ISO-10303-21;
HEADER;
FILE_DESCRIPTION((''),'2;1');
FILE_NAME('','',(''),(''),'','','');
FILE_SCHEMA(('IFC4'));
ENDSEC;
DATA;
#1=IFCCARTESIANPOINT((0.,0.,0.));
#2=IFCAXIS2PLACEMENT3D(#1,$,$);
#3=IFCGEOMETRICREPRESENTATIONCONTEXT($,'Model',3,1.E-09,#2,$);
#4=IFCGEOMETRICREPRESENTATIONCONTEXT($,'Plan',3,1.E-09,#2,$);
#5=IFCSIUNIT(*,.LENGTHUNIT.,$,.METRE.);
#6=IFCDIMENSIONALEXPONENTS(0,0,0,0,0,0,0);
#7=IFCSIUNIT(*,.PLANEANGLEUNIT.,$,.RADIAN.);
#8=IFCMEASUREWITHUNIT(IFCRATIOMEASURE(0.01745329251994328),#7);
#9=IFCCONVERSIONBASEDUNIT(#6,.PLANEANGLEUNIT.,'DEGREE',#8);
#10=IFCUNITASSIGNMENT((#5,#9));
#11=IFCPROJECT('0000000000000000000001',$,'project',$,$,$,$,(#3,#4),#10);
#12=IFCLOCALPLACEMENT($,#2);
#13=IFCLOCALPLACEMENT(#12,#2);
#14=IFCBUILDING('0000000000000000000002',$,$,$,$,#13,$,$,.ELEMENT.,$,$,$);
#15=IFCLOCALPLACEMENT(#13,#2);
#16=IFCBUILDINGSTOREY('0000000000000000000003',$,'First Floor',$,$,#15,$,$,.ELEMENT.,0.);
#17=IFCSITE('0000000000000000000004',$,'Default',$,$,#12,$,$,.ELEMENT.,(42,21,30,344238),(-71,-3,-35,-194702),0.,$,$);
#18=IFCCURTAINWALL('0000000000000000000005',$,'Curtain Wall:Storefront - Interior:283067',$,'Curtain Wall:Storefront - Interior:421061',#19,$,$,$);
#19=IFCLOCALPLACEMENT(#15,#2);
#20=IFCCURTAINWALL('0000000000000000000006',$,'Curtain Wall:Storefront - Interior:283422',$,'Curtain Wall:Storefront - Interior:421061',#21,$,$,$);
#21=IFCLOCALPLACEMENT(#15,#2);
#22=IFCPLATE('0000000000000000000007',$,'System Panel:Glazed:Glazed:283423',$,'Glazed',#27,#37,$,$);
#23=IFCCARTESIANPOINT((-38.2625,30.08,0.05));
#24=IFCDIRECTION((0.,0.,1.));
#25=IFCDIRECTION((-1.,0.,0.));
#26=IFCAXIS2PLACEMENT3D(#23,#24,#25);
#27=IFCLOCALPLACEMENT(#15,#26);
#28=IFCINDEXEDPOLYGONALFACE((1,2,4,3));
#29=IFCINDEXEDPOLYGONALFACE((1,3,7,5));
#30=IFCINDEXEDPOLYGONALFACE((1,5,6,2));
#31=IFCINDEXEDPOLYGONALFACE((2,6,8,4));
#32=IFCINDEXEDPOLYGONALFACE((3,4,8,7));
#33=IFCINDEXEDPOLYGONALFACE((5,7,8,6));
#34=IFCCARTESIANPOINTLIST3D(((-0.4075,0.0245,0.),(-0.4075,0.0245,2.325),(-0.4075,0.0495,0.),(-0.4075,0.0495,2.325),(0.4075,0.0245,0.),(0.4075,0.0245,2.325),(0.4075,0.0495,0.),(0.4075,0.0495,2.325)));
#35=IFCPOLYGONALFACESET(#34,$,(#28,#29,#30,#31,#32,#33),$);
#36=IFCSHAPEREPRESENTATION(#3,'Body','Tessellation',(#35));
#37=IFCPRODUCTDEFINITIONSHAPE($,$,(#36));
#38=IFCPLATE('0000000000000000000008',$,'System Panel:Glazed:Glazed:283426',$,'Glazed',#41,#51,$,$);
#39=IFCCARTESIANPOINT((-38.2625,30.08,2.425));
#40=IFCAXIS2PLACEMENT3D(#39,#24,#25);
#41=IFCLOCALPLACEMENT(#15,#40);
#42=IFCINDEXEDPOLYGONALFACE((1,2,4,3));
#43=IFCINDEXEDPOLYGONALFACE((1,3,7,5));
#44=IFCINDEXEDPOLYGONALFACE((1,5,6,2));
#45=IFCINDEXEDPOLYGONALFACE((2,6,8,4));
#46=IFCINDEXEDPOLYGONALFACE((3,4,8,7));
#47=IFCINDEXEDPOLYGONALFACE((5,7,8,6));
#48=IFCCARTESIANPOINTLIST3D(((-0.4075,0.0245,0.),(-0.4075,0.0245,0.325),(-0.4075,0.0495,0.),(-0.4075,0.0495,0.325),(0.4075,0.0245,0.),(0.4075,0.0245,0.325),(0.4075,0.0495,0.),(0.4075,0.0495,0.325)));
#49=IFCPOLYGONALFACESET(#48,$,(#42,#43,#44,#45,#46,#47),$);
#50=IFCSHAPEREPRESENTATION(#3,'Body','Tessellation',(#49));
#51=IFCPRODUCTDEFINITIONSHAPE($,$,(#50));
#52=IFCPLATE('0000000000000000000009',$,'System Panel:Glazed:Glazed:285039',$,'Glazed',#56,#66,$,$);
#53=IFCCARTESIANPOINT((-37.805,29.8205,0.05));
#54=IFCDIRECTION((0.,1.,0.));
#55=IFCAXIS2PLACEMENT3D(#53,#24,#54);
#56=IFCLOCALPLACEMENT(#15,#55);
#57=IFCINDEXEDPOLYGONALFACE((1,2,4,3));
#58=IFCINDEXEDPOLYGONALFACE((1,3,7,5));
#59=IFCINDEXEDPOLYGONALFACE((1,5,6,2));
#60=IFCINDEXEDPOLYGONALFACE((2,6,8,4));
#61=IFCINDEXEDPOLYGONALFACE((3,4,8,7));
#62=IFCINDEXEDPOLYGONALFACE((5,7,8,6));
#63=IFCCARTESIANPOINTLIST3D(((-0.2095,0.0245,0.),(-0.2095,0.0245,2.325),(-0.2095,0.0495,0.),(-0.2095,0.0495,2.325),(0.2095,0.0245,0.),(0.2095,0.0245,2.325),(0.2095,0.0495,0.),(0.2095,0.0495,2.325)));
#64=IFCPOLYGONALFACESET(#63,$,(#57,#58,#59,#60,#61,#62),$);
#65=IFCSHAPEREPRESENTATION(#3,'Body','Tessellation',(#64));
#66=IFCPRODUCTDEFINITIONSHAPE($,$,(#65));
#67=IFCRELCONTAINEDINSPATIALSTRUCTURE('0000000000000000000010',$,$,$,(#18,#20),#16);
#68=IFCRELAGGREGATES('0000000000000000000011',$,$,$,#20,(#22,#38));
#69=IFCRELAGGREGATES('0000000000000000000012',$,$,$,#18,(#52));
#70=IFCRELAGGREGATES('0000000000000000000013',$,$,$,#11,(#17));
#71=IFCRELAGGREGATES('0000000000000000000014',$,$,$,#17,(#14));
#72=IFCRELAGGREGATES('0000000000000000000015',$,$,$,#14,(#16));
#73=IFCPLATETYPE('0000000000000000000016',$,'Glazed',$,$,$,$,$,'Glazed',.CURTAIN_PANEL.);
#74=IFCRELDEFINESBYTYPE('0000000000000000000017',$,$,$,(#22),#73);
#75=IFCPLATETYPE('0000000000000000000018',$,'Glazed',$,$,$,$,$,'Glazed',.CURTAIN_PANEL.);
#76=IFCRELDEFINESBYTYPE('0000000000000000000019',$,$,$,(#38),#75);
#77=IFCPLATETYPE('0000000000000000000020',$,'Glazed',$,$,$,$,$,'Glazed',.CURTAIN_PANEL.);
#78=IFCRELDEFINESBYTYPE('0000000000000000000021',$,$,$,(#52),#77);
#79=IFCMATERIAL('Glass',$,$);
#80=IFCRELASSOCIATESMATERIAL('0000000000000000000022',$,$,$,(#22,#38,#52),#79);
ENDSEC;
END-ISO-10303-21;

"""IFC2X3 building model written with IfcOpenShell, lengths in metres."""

from ifc_helpers import new_model, entity, si_unit, converted_unit, frame, origin, origin_2d_with_axis, place, context, project, spatial, rectangle, extrude, source, transform, mapped, material, type_object, type_shapes, element, aggregate, save


model = new_model("IFC2X3")

# Units and contexts
model_context = context("Model", 3, precision=1e-09, world=origin())
plan_context = context("Plan", 3, precision=1e-09, world=origin())
ifc_project = project(units=[si_unit("LENGTHUNIT", "METRE"), converted_unit("PLANEANGLEUNIT", "DEGREE", entity("IfcRatioMeasure", 0.01745329251994328), si_unit("PLANEANGLEUNIT", "RADIAN"), dimensions=[0, 0, 0, 0, 0, 0, 0])], contexts=[model_context, plan_context])

# Site, building, storey
site_placement = place(None, origin())
site = spatial("IfcSite", under=ifc_project, at=site_placement, Name="Default", CompositionType="ELEMENT", RefLatitude=(42, 21, 30, 344238), RefLongitude=(-71, -3, -35, -194702), RefElevation=0.0)
building_placement = place(site_placement, origin())
building = spatial("IfcBuilding", under=site, at=building_placement, CompositionType="ELEMENT")
storey_placement = place(building_placement, origin())
storey = spatial("IfcBuildingStorey", under=building, at=storey_placement, Name="First Floor", CompositionType="ELEMENT", Elevation=0.0)

# Curtain walls
curtain_wall_1_placement = place(storey_placement, origin())
curtain_wall_1 = element("IfcCurtainWall", 1, at=curtain_wall_1_placement, inside=storey, Name="Curtain Wall:Storefront - Interior:283067", ObjectType="Curtain Wall:Storefront - Interior:421061")
curtain_wall_2_placement = place(storey_placement, origin())
curtain_wall_2 = element("IfcCurtainWall", 2, at=curtain_wall_2_placement, inside=storey, Name="Curtain Wall:Storefront - Interior:283422", ObjectType="Curtain Wall:Storefront - Interior:421061")

# Plates
ifc_material_1 = material(Name="Glass")
plate_type_1 = type_object("IfcPlateType", Name="Glazed", ElementType="Glazed", PredefinedType="CURTAIN_PANEL")
shared_shape_1 = source(origin(), model_context, "Body", "SweptSolid", [
    extrude(rectangle(XDim=0.025, YDim=0.815, at=origin_2d_with_axis()), frame((0.0, 0.037, 0.0), z_axis=(0.0, 0.0, 1.0), x_axis=(0.0, 1.0, 0.0)), (0.0, 0.0, 1.0), 2.325),
])
type_shapes(plate_type_1, [shared_shape_1])
plate_1_placement = place(storey_placement, frame((-38.2625, 30.08, 0.05), z_axis=(0.0, 0.0, 1.0), x_axis=(-1.0, 0.0, 0.0)))
plate_1 = element("IfcPlate", 3, at=plate_1_placement, type_object=plate_type_1, material=ifc_material_1, Name="System Panel:Glazed:Glazed:283423", ObjectType="Glazed", context=model_context, shape_type="MappedRepresentation", body=[
    mapped(shared_shape_1, transform((0.0, 0.0, 0.0), scale=1.0)),
])
plate_type_2 = type_object("IfcPlateType", Name="Glazed", ElementType="Glazed", PredefinedType="CURTAIN_PANEL")
shared_shape_2 = source(origin(), model_context, "Body", "SweptSolid", [
    extrude(rectangle(XDim=0.025, YDim=0.815, at=origin_2d_with_axis()), frame((0.0, 0.037, 0.0), z_axis=(0.0, 0.0, 1.0), x_axis=(0.0, 1.0, 0.0)), (0.0, 0.0, 1.0), 0.325),
])
type_shapes(plate_type_2, [shared_shape_2])
plate_2_placement = place(storey_placement, frame((-38.2625, 30.08, 2.425), z_axis=(0.0, 0.0, 1.0), x_axis=(-1.0, 0.0, 0.0)))
plate_2 = element("IfcPlate", 4, at=plate_2_placement, type_object=plate_type_2, material=ifc_material_1, Name="System Panel:Glazed:Glazed:283426", ObjectType="Glazed", context=model_context, shape_type="MappedRepresentation", body=[
    mapped(shared_shape_2, transform((0.0, 0.0, 0.0), scale=1.0)),
])
aggregate(curtain_wall_2, [plate_1, plate_2])
plate_type_3 = type_object("IfcPlateType", Name="Glazed", ElementType="Glazed", PredefinedType="CURTAIN_PANEL")
shared_shape_3 = source(origin(), model_context, "Body", "SweptSolid", [
    extrude(rectangle(XDim=0.025, YDim=0.419, at=origin_2d_with_axis()), frame((0.0, 0.037, 0.0), z_axis=(0.0, 0.0, 1.0), x_axis=(0.0, 1.0, 0.0)), (0.0, 0.0, 1.0), 2.325),
])
type_shapes(plate_type_3, [shared_shape_3])
plate_3_placement = place(storey_placement, frame((-37.805, 29.8205, 0.05), z_axis=(0.0, 0.0, 1.0), x_axis=(0.0, 1.0, 0.0)))
plate_3 = element("IfcPlate", 5, at=plate_3_placement, type_object=plate_type_3, material=ifc_material_1, Name="System Panel:Glazed:Glazed:285039", ObjectType="Glazed", context=model_context, shape_type="MappedRepresentation", body=[
    mapped(shared_shape_3, transform((0.0, 0.0, 0.0), scale=1.0)),
])
aggregate(curtain_wall_1, [plate_3])

save(model, "model.ifc")
